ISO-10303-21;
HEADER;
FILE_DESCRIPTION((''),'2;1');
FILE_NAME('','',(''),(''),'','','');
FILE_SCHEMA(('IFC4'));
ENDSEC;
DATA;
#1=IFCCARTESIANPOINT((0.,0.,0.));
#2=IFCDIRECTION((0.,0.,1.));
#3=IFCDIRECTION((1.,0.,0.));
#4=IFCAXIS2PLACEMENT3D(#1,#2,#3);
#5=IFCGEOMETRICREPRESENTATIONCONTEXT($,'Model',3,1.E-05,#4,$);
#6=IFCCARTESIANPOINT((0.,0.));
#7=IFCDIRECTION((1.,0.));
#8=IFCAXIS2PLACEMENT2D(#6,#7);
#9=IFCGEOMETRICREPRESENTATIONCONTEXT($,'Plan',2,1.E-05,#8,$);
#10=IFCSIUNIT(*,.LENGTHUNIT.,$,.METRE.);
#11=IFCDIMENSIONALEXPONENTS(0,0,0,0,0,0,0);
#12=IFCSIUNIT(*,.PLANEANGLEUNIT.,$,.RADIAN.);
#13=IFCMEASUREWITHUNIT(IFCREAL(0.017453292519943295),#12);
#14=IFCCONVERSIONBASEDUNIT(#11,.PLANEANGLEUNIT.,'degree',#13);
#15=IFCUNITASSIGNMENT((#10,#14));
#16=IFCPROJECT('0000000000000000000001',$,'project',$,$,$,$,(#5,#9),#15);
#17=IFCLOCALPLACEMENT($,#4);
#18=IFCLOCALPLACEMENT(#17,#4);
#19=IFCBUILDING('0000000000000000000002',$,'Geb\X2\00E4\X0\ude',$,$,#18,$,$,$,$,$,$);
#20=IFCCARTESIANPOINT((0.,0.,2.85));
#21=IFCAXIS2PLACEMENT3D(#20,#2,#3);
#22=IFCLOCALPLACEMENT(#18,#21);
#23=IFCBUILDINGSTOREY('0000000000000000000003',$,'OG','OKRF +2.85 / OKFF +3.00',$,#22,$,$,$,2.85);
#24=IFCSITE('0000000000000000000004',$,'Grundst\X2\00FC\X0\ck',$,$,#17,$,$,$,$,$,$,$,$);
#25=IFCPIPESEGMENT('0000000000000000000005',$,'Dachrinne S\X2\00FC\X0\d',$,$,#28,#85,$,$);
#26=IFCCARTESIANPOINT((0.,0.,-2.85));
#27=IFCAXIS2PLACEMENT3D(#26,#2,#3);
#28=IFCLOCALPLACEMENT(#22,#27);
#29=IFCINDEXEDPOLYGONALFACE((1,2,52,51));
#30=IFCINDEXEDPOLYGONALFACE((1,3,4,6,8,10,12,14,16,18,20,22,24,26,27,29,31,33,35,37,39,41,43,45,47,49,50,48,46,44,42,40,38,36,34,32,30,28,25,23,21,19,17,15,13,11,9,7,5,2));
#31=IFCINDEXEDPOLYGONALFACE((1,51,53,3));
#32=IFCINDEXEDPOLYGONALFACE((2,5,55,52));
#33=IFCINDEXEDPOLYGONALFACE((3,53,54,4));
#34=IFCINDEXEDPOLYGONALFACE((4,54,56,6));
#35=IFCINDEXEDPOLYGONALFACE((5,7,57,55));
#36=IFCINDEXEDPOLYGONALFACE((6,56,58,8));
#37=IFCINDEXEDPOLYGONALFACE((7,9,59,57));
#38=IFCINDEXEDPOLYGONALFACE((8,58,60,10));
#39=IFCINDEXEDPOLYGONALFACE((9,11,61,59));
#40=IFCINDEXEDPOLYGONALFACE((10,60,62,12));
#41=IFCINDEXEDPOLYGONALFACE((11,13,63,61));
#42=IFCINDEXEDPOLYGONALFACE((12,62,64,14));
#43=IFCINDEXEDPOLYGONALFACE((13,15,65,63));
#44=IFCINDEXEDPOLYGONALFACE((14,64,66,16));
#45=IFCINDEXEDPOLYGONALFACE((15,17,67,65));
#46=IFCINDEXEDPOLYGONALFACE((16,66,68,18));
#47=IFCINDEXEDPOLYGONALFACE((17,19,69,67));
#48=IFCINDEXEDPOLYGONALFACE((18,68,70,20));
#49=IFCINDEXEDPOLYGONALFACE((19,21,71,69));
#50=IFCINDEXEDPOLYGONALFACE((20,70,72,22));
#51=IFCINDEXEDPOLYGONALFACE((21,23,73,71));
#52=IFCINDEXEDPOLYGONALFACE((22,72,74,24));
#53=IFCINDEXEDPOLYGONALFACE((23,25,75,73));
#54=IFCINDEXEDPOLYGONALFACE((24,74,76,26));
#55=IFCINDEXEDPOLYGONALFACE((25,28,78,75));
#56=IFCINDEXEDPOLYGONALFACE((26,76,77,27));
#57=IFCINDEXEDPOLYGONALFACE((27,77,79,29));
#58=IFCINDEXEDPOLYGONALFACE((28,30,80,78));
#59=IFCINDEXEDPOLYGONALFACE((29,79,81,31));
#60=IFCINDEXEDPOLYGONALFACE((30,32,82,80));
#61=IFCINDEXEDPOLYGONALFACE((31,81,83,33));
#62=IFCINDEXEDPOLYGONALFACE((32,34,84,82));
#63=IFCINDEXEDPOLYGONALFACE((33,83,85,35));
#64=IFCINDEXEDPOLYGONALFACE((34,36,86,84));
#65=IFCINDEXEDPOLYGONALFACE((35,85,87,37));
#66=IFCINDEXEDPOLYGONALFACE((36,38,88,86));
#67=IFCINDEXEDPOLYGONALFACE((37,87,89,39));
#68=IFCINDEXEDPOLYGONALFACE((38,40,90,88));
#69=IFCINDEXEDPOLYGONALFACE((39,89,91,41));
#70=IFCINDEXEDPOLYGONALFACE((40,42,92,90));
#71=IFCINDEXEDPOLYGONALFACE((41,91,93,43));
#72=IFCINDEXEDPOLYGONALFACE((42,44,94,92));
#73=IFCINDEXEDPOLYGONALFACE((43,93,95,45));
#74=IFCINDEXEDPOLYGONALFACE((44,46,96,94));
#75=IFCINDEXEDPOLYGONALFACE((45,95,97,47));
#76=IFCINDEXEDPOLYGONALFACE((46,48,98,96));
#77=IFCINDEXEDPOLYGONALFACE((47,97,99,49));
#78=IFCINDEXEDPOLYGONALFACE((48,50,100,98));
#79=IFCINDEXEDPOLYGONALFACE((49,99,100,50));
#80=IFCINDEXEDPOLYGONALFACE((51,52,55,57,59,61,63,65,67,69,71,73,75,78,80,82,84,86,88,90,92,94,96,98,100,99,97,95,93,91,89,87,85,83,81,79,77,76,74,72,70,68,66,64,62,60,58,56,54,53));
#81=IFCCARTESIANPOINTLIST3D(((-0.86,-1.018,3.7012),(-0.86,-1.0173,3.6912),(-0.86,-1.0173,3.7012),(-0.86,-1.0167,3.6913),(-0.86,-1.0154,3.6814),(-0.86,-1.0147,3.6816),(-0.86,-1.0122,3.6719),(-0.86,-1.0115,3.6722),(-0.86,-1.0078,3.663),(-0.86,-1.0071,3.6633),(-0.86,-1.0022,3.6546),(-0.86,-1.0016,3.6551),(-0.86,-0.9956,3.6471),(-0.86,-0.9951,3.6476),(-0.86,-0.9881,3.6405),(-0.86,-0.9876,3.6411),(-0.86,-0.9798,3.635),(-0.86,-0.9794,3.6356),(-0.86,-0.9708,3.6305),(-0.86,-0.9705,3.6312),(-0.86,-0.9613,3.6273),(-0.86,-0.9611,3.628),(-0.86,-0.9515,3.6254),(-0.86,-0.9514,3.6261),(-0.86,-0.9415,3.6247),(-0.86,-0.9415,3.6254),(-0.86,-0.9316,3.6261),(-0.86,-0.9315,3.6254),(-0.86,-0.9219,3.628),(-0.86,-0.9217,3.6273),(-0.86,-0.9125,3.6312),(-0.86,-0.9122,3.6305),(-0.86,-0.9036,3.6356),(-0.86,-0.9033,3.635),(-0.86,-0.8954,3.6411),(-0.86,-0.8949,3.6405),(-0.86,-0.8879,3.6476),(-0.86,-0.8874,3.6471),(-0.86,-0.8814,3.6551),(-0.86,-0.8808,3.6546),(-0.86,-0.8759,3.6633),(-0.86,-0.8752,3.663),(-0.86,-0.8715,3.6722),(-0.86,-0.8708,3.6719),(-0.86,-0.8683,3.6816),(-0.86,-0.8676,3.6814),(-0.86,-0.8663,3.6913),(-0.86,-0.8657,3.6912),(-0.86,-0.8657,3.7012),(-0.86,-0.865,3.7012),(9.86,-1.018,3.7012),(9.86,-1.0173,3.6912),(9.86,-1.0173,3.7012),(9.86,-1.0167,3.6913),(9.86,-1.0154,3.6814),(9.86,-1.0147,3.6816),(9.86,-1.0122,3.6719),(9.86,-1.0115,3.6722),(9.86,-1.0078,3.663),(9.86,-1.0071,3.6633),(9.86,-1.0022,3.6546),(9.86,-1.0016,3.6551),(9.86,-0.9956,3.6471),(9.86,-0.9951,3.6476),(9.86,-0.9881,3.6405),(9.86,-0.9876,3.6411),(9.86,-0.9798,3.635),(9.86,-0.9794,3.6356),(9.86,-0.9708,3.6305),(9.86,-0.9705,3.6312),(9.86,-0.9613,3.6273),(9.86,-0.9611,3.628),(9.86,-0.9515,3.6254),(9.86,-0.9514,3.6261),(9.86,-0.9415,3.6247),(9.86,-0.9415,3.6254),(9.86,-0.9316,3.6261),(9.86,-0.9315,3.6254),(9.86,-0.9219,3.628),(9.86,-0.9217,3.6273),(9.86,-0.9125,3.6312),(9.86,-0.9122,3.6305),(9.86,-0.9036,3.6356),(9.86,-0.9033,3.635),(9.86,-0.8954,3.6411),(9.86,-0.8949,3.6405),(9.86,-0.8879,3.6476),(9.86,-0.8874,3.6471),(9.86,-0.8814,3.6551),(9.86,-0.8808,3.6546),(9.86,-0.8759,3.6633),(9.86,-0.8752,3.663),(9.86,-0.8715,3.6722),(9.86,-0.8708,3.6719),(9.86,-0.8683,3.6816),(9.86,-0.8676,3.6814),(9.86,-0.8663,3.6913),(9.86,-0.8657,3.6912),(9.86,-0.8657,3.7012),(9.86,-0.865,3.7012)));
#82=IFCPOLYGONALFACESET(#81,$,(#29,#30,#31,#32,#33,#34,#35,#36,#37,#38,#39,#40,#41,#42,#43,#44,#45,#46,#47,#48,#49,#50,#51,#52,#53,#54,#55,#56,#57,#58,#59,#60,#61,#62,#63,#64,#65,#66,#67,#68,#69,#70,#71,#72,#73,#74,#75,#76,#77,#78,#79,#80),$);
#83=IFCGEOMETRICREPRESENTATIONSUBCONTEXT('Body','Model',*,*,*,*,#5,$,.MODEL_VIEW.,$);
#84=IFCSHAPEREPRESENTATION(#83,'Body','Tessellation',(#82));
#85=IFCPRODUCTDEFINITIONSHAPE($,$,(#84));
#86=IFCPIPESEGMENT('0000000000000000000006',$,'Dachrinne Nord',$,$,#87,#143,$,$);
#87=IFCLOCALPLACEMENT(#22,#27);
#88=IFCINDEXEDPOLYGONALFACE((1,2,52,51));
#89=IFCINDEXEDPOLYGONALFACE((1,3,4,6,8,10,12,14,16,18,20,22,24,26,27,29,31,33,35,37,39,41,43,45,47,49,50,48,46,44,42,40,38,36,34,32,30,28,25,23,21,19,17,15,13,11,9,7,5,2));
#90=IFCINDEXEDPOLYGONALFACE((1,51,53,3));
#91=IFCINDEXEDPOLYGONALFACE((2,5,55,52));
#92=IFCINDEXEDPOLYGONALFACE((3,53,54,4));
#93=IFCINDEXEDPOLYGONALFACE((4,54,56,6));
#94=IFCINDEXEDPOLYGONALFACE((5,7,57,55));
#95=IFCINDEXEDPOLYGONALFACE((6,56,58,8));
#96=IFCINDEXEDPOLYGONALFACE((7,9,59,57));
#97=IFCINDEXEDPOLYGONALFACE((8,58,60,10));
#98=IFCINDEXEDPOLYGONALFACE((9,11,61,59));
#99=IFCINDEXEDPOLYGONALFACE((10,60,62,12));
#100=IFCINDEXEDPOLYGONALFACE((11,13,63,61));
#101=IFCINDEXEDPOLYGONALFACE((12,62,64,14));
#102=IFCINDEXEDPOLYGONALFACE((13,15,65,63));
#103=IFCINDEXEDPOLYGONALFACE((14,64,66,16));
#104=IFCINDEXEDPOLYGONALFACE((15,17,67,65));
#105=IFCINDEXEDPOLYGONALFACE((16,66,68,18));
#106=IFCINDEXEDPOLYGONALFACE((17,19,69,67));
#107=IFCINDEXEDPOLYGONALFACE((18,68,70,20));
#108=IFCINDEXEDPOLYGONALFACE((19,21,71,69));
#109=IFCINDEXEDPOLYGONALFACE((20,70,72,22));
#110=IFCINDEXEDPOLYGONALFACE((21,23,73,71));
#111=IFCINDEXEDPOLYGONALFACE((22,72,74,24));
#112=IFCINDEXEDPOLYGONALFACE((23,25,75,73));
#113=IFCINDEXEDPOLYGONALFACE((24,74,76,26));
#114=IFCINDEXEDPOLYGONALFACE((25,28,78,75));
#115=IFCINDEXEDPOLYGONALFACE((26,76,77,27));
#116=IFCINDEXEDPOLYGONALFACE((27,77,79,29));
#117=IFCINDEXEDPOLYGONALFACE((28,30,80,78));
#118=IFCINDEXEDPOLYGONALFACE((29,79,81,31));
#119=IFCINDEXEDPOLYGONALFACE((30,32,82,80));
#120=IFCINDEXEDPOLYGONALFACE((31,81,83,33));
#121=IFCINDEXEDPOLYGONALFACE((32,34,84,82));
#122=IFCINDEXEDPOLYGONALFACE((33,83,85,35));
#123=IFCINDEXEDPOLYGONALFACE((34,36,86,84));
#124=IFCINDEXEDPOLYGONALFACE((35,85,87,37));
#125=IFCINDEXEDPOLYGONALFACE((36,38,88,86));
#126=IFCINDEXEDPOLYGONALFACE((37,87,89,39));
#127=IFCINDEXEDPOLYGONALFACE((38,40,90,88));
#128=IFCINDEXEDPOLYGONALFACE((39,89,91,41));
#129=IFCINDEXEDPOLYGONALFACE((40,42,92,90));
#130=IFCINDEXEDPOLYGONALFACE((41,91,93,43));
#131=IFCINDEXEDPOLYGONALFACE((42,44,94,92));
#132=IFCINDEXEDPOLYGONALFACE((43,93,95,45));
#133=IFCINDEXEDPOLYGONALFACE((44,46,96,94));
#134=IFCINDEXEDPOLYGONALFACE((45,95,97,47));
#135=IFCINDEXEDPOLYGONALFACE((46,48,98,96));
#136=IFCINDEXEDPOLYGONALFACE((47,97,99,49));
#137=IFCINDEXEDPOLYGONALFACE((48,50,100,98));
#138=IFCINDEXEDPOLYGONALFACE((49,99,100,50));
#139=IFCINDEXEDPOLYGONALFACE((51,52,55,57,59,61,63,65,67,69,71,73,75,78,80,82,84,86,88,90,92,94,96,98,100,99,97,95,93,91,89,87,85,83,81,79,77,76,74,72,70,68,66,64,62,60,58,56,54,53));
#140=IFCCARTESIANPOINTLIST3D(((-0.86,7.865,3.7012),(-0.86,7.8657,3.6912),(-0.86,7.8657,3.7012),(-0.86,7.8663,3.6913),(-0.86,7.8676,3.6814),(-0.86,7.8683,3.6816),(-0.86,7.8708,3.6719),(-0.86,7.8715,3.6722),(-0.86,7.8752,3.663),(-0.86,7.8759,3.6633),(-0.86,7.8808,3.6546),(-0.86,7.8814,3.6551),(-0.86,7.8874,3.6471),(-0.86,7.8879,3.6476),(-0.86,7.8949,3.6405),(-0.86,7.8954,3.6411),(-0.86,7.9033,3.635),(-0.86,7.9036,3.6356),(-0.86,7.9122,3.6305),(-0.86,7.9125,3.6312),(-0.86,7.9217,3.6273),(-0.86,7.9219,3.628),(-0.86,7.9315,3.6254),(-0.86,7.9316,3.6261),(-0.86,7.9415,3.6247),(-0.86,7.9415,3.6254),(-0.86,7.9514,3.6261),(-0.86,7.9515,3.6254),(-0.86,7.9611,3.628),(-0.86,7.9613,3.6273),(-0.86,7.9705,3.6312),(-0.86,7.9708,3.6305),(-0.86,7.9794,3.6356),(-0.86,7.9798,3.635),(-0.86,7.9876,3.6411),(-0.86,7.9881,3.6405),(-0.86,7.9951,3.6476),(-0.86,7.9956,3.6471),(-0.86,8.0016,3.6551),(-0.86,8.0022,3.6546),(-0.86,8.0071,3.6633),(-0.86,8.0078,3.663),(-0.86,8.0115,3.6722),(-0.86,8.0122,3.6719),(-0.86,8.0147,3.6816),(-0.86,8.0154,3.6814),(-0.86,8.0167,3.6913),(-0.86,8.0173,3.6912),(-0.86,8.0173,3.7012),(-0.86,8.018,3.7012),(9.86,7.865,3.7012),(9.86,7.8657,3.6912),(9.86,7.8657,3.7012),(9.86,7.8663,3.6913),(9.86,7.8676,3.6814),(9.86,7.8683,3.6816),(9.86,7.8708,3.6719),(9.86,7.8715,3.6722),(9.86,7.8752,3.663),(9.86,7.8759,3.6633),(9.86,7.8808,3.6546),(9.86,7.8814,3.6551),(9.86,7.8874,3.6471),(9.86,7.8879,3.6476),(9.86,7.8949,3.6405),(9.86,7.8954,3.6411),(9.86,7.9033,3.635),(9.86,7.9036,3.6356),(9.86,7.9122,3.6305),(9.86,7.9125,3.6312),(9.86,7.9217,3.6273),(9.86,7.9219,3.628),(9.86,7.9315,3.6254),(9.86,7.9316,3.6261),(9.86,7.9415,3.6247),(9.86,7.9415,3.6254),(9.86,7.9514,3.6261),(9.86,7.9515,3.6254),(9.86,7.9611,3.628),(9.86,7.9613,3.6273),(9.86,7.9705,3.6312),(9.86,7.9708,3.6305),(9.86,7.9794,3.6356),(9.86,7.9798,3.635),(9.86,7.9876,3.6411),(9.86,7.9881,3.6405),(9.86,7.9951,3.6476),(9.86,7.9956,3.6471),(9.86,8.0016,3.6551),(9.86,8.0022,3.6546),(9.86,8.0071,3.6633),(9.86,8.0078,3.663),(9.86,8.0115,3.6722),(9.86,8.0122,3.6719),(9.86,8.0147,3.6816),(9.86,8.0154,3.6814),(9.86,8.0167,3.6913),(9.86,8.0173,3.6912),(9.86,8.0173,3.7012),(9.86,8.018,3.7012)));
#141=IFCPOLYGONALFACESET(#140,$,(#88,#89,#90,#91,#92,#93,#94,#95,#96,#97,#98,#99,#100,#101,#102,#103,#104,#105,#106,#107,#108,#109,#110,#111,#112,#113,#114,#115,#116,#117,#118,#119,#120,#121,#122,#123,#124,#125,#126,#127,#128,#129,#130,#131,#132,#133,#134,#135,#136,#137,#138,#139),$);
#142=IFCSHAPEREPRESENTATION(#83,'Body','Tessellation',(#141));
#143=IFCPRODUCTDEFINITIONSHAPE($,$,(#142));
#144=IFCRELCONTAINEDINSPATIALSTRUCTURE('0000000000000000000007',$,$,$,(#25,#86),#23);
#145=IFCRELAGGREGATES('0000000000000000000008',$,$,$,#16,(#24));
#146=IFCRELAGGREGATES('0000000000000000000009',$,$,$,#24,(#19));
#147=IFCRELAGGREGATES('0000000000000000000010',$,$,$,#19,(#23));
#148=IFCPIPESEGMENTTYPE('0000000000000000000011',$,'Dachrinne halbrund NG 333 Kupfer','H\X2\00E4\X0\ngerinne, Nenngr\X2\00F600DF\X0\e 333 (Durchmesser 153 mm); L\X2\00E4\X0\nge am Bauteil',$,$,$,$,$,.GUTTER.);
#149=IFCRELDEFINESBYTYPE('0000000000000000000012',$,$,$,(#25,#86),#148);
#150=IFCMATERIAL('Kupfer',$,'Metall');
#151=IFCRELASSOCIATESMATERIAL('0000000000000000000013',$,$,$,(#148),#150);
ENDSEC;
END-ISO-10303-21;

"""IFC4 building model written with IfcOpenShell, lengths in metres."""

from ifc_helpers import new_model, entity, si_unit, converted_unit, frame, origin_with_axes, origin_2d_with_axis, place, context, subcontext, project, spatial, polyline, outline, extrude, material, type_object, element, save


model = new_model("IFC4")

# Units and contexts
model_context = context("Model", 3, precision=1e-05, world=origin_with_axes())
plan_context = context("Plan", 2, precision=1e-05, world=origin_2d_with_axis())
body_context = subcontext(model_context, "Body", "Model", "MODEL_VIEW")
ifc_project = project(units=[si_unit("LENGTHUNIT", "METRE"), converted_unit("PLANEANGLEUNIT", "degree", entity("IfcReal", 0.017453292519943295), si_unit("PLANEANGLEUNIT", "RADIAN"), dimensions=[0, 0, 0, 0, 0, 0, 0])], contexts=[model_context, plan_context])

# Site, building, storey
site_placement = place(None, origin_with_axes())
site = spatial("IfcSite", under=ifc_project, at=site_placement, Name="Grundstück")
building_placement = place(site_placement, origin_with_axes())
building = spatial("IfcBuilding", under=site, at=building_placement, Name="Gebäude")
storey_placement = place(building_placement, frame((0.0, 0.0, 2.85), z_axis=(0.0, 0.0, 1.0), x_axis=(1.0, 0.0, 0.0)))
storey = spatial("IfcBuildingStorey", under=building, at=storey_placement, Name="OG", Description="OKRF +2.85 / OKFF +3.00", Elevation=2.85)

# Pipe segments
ifc_material_1 = material(Name="Kupfer", Category="Metall")
pipe_segment_type = type_object("IfcPipeSegmentType", Name="Dachrinne halbrund NG 333 Kupfer", Description="Hängerinne, Nenngröße 333 (Durchmesser 153 mm); Länge am Bauteil", PredefinedType="GUTTER", material=ifc_material_1)
pipe_segment_1_placement = place(storey_placement, frame((0.0, 0.0, -2.85), z_axis=(0.0, 0.0, 1.0), x_axis=(1.0, 0.0, 0.0)))
element("IfcPipeSegment", 1, at=pipe_segment_1_placement, inside=storey, type_object=pipe_segment_type, Name="Dachrinne Süd", context=body_context, shape_type="SweptSolid", body=[
    extrude(outline(polyline([(-1.018, 3.7012), (-1.0173, 3.6912), (-1.0154, 3.6814), (-1.0122, 3.6719), (-1.0078, 3.663), (-1.0022, 3.6546), (-0.9956, 3.6471), (-0.9881, 3.6405), (-0.9798, 3.635), (-0.9708, 3.6305), (-0.9613, 3.6273), (-0.9515, 3.6254), (-0.9415, 3.6247), (-0.9315, 3.6254), (-0.9217, 3.6273), (-0.9122, 3.6305), (-0.9033, 3.635), (-0.8949, 3.6405), (-0.8874, 3.6471), (-0.8808, 3.6546), (-0.8752, 3.663), (-0.8708, 3.6719), (-0.8676, 3.6814), (-0.8657, 3.6912), (-0.865, 3.7012), (-0.8657, 3.7012), (-0.8663, 3.6913), (-0.8683, 3.6816), (-0.8715, 3.6722), (-0.8759, 3.6633), (-0.8814, 3.6551), (-0.8879, 3.6476), (-0.8954, 3.6411), (-0.9036, 3.6356), (-0.9125, 3.6312), (-0.9219, 3.628), (-0.9316, 3.6261), (-0.9415, 3.6254), (-0.9514, 3.6261), (-0.9611, 3.628), (-0.9705, 3.6312), (-0.9794, 3.6356), (-0.9876, 3.6411), (-0.9951, 3.6476), (-1.0016, 3.6551), (-1.0071, 3.6633), (-1.0115, 3.6722), (-1.0147, 3.6816), (-1.0167, 3.6913), (-1.0173, 3.7012), (-1.018, 3.7012)])), frame((-0.86, 0.0, 0.0), z_axis=(1.0, 0.0, 0.0), x_axis=(0.0, 1.0, 0.0)), (0.0, 0.0, 1.0), 10.72),
])
pipe_segment_2_placement = place(storey_placement, frame((0.0, 0.0, -2.85), z_axis=(0.0, 0.0, 1.0), x_axis=(1.0, 0.0, 0.0)))
element("IfcPipeSegment", 2, at=pipe_segment_2_placement, inside=storey, type_object=pipe_segment_type, Name="Dachrinne Nord", context=body_context, shape_type="SweptSolid", body=[
    extrude(outline(polyline([(7.865, 3.7012), (7.8657, 3.6912), (7.8676, 3.6814), (7.8708, 3.6719), (7.8752, 3.663), (7.8808, 3.6546), (7.8874, 3.6471), (7.8949, 3.6405), (7.9033, 3.635), (7.9122, 3.6305), (7.9217, 3.6273), (7.9315, 3.6254), (7.9415, 3.6247), (7.9515, 3.6254), (7.9613, 3.6273), (7.9708, 3.6305), (7.9798, 3.635), (7.9881, 3.6405), (7.9956, 3.6471), (8.0022, 3.6546), (8.0078, 3.663), (8.0122, 3.6719), (8.0154, 3.6814), (8.0173, 3.6912), (8.018, 3.7012), (8.0173, 3.7012), (8.0167, 3.6913), (8.0147, 3.6816), (8.0115, 3.6722), (8.0071, 3.6633), (8.0016, 3.6551), (7.9951, 3.6476), (7.9876, 3.6411), (7.9794, 3.6356), (7.9705, 3.6312), (7.9611, 3.628), (7.9514, 3.6261), (7.9415, 3.6254), (7.9316, 3.6261), (7.9219, 3.628), (7.9125, 3.6312), (7.9036, 3.6356), (7.8954, 3.6411), (7.8879, 3.6476), (7.8814, 3.6551), (7.8759, 3.6633), (7.8715, 3.6722), (7.8683, 3.6816), (7.8663, 3.6913), (7.8657, 3.7012), (7.865, 3.7012)])), frame((-0.86, 0.0, 0.0), z_axis=(1.0, 0.0, 0.0), x_axis=(0.0, 1.0, 0.0)), (0.0, 0.0, 1.0), 10.72),
])

save(model, "model.ifc")
